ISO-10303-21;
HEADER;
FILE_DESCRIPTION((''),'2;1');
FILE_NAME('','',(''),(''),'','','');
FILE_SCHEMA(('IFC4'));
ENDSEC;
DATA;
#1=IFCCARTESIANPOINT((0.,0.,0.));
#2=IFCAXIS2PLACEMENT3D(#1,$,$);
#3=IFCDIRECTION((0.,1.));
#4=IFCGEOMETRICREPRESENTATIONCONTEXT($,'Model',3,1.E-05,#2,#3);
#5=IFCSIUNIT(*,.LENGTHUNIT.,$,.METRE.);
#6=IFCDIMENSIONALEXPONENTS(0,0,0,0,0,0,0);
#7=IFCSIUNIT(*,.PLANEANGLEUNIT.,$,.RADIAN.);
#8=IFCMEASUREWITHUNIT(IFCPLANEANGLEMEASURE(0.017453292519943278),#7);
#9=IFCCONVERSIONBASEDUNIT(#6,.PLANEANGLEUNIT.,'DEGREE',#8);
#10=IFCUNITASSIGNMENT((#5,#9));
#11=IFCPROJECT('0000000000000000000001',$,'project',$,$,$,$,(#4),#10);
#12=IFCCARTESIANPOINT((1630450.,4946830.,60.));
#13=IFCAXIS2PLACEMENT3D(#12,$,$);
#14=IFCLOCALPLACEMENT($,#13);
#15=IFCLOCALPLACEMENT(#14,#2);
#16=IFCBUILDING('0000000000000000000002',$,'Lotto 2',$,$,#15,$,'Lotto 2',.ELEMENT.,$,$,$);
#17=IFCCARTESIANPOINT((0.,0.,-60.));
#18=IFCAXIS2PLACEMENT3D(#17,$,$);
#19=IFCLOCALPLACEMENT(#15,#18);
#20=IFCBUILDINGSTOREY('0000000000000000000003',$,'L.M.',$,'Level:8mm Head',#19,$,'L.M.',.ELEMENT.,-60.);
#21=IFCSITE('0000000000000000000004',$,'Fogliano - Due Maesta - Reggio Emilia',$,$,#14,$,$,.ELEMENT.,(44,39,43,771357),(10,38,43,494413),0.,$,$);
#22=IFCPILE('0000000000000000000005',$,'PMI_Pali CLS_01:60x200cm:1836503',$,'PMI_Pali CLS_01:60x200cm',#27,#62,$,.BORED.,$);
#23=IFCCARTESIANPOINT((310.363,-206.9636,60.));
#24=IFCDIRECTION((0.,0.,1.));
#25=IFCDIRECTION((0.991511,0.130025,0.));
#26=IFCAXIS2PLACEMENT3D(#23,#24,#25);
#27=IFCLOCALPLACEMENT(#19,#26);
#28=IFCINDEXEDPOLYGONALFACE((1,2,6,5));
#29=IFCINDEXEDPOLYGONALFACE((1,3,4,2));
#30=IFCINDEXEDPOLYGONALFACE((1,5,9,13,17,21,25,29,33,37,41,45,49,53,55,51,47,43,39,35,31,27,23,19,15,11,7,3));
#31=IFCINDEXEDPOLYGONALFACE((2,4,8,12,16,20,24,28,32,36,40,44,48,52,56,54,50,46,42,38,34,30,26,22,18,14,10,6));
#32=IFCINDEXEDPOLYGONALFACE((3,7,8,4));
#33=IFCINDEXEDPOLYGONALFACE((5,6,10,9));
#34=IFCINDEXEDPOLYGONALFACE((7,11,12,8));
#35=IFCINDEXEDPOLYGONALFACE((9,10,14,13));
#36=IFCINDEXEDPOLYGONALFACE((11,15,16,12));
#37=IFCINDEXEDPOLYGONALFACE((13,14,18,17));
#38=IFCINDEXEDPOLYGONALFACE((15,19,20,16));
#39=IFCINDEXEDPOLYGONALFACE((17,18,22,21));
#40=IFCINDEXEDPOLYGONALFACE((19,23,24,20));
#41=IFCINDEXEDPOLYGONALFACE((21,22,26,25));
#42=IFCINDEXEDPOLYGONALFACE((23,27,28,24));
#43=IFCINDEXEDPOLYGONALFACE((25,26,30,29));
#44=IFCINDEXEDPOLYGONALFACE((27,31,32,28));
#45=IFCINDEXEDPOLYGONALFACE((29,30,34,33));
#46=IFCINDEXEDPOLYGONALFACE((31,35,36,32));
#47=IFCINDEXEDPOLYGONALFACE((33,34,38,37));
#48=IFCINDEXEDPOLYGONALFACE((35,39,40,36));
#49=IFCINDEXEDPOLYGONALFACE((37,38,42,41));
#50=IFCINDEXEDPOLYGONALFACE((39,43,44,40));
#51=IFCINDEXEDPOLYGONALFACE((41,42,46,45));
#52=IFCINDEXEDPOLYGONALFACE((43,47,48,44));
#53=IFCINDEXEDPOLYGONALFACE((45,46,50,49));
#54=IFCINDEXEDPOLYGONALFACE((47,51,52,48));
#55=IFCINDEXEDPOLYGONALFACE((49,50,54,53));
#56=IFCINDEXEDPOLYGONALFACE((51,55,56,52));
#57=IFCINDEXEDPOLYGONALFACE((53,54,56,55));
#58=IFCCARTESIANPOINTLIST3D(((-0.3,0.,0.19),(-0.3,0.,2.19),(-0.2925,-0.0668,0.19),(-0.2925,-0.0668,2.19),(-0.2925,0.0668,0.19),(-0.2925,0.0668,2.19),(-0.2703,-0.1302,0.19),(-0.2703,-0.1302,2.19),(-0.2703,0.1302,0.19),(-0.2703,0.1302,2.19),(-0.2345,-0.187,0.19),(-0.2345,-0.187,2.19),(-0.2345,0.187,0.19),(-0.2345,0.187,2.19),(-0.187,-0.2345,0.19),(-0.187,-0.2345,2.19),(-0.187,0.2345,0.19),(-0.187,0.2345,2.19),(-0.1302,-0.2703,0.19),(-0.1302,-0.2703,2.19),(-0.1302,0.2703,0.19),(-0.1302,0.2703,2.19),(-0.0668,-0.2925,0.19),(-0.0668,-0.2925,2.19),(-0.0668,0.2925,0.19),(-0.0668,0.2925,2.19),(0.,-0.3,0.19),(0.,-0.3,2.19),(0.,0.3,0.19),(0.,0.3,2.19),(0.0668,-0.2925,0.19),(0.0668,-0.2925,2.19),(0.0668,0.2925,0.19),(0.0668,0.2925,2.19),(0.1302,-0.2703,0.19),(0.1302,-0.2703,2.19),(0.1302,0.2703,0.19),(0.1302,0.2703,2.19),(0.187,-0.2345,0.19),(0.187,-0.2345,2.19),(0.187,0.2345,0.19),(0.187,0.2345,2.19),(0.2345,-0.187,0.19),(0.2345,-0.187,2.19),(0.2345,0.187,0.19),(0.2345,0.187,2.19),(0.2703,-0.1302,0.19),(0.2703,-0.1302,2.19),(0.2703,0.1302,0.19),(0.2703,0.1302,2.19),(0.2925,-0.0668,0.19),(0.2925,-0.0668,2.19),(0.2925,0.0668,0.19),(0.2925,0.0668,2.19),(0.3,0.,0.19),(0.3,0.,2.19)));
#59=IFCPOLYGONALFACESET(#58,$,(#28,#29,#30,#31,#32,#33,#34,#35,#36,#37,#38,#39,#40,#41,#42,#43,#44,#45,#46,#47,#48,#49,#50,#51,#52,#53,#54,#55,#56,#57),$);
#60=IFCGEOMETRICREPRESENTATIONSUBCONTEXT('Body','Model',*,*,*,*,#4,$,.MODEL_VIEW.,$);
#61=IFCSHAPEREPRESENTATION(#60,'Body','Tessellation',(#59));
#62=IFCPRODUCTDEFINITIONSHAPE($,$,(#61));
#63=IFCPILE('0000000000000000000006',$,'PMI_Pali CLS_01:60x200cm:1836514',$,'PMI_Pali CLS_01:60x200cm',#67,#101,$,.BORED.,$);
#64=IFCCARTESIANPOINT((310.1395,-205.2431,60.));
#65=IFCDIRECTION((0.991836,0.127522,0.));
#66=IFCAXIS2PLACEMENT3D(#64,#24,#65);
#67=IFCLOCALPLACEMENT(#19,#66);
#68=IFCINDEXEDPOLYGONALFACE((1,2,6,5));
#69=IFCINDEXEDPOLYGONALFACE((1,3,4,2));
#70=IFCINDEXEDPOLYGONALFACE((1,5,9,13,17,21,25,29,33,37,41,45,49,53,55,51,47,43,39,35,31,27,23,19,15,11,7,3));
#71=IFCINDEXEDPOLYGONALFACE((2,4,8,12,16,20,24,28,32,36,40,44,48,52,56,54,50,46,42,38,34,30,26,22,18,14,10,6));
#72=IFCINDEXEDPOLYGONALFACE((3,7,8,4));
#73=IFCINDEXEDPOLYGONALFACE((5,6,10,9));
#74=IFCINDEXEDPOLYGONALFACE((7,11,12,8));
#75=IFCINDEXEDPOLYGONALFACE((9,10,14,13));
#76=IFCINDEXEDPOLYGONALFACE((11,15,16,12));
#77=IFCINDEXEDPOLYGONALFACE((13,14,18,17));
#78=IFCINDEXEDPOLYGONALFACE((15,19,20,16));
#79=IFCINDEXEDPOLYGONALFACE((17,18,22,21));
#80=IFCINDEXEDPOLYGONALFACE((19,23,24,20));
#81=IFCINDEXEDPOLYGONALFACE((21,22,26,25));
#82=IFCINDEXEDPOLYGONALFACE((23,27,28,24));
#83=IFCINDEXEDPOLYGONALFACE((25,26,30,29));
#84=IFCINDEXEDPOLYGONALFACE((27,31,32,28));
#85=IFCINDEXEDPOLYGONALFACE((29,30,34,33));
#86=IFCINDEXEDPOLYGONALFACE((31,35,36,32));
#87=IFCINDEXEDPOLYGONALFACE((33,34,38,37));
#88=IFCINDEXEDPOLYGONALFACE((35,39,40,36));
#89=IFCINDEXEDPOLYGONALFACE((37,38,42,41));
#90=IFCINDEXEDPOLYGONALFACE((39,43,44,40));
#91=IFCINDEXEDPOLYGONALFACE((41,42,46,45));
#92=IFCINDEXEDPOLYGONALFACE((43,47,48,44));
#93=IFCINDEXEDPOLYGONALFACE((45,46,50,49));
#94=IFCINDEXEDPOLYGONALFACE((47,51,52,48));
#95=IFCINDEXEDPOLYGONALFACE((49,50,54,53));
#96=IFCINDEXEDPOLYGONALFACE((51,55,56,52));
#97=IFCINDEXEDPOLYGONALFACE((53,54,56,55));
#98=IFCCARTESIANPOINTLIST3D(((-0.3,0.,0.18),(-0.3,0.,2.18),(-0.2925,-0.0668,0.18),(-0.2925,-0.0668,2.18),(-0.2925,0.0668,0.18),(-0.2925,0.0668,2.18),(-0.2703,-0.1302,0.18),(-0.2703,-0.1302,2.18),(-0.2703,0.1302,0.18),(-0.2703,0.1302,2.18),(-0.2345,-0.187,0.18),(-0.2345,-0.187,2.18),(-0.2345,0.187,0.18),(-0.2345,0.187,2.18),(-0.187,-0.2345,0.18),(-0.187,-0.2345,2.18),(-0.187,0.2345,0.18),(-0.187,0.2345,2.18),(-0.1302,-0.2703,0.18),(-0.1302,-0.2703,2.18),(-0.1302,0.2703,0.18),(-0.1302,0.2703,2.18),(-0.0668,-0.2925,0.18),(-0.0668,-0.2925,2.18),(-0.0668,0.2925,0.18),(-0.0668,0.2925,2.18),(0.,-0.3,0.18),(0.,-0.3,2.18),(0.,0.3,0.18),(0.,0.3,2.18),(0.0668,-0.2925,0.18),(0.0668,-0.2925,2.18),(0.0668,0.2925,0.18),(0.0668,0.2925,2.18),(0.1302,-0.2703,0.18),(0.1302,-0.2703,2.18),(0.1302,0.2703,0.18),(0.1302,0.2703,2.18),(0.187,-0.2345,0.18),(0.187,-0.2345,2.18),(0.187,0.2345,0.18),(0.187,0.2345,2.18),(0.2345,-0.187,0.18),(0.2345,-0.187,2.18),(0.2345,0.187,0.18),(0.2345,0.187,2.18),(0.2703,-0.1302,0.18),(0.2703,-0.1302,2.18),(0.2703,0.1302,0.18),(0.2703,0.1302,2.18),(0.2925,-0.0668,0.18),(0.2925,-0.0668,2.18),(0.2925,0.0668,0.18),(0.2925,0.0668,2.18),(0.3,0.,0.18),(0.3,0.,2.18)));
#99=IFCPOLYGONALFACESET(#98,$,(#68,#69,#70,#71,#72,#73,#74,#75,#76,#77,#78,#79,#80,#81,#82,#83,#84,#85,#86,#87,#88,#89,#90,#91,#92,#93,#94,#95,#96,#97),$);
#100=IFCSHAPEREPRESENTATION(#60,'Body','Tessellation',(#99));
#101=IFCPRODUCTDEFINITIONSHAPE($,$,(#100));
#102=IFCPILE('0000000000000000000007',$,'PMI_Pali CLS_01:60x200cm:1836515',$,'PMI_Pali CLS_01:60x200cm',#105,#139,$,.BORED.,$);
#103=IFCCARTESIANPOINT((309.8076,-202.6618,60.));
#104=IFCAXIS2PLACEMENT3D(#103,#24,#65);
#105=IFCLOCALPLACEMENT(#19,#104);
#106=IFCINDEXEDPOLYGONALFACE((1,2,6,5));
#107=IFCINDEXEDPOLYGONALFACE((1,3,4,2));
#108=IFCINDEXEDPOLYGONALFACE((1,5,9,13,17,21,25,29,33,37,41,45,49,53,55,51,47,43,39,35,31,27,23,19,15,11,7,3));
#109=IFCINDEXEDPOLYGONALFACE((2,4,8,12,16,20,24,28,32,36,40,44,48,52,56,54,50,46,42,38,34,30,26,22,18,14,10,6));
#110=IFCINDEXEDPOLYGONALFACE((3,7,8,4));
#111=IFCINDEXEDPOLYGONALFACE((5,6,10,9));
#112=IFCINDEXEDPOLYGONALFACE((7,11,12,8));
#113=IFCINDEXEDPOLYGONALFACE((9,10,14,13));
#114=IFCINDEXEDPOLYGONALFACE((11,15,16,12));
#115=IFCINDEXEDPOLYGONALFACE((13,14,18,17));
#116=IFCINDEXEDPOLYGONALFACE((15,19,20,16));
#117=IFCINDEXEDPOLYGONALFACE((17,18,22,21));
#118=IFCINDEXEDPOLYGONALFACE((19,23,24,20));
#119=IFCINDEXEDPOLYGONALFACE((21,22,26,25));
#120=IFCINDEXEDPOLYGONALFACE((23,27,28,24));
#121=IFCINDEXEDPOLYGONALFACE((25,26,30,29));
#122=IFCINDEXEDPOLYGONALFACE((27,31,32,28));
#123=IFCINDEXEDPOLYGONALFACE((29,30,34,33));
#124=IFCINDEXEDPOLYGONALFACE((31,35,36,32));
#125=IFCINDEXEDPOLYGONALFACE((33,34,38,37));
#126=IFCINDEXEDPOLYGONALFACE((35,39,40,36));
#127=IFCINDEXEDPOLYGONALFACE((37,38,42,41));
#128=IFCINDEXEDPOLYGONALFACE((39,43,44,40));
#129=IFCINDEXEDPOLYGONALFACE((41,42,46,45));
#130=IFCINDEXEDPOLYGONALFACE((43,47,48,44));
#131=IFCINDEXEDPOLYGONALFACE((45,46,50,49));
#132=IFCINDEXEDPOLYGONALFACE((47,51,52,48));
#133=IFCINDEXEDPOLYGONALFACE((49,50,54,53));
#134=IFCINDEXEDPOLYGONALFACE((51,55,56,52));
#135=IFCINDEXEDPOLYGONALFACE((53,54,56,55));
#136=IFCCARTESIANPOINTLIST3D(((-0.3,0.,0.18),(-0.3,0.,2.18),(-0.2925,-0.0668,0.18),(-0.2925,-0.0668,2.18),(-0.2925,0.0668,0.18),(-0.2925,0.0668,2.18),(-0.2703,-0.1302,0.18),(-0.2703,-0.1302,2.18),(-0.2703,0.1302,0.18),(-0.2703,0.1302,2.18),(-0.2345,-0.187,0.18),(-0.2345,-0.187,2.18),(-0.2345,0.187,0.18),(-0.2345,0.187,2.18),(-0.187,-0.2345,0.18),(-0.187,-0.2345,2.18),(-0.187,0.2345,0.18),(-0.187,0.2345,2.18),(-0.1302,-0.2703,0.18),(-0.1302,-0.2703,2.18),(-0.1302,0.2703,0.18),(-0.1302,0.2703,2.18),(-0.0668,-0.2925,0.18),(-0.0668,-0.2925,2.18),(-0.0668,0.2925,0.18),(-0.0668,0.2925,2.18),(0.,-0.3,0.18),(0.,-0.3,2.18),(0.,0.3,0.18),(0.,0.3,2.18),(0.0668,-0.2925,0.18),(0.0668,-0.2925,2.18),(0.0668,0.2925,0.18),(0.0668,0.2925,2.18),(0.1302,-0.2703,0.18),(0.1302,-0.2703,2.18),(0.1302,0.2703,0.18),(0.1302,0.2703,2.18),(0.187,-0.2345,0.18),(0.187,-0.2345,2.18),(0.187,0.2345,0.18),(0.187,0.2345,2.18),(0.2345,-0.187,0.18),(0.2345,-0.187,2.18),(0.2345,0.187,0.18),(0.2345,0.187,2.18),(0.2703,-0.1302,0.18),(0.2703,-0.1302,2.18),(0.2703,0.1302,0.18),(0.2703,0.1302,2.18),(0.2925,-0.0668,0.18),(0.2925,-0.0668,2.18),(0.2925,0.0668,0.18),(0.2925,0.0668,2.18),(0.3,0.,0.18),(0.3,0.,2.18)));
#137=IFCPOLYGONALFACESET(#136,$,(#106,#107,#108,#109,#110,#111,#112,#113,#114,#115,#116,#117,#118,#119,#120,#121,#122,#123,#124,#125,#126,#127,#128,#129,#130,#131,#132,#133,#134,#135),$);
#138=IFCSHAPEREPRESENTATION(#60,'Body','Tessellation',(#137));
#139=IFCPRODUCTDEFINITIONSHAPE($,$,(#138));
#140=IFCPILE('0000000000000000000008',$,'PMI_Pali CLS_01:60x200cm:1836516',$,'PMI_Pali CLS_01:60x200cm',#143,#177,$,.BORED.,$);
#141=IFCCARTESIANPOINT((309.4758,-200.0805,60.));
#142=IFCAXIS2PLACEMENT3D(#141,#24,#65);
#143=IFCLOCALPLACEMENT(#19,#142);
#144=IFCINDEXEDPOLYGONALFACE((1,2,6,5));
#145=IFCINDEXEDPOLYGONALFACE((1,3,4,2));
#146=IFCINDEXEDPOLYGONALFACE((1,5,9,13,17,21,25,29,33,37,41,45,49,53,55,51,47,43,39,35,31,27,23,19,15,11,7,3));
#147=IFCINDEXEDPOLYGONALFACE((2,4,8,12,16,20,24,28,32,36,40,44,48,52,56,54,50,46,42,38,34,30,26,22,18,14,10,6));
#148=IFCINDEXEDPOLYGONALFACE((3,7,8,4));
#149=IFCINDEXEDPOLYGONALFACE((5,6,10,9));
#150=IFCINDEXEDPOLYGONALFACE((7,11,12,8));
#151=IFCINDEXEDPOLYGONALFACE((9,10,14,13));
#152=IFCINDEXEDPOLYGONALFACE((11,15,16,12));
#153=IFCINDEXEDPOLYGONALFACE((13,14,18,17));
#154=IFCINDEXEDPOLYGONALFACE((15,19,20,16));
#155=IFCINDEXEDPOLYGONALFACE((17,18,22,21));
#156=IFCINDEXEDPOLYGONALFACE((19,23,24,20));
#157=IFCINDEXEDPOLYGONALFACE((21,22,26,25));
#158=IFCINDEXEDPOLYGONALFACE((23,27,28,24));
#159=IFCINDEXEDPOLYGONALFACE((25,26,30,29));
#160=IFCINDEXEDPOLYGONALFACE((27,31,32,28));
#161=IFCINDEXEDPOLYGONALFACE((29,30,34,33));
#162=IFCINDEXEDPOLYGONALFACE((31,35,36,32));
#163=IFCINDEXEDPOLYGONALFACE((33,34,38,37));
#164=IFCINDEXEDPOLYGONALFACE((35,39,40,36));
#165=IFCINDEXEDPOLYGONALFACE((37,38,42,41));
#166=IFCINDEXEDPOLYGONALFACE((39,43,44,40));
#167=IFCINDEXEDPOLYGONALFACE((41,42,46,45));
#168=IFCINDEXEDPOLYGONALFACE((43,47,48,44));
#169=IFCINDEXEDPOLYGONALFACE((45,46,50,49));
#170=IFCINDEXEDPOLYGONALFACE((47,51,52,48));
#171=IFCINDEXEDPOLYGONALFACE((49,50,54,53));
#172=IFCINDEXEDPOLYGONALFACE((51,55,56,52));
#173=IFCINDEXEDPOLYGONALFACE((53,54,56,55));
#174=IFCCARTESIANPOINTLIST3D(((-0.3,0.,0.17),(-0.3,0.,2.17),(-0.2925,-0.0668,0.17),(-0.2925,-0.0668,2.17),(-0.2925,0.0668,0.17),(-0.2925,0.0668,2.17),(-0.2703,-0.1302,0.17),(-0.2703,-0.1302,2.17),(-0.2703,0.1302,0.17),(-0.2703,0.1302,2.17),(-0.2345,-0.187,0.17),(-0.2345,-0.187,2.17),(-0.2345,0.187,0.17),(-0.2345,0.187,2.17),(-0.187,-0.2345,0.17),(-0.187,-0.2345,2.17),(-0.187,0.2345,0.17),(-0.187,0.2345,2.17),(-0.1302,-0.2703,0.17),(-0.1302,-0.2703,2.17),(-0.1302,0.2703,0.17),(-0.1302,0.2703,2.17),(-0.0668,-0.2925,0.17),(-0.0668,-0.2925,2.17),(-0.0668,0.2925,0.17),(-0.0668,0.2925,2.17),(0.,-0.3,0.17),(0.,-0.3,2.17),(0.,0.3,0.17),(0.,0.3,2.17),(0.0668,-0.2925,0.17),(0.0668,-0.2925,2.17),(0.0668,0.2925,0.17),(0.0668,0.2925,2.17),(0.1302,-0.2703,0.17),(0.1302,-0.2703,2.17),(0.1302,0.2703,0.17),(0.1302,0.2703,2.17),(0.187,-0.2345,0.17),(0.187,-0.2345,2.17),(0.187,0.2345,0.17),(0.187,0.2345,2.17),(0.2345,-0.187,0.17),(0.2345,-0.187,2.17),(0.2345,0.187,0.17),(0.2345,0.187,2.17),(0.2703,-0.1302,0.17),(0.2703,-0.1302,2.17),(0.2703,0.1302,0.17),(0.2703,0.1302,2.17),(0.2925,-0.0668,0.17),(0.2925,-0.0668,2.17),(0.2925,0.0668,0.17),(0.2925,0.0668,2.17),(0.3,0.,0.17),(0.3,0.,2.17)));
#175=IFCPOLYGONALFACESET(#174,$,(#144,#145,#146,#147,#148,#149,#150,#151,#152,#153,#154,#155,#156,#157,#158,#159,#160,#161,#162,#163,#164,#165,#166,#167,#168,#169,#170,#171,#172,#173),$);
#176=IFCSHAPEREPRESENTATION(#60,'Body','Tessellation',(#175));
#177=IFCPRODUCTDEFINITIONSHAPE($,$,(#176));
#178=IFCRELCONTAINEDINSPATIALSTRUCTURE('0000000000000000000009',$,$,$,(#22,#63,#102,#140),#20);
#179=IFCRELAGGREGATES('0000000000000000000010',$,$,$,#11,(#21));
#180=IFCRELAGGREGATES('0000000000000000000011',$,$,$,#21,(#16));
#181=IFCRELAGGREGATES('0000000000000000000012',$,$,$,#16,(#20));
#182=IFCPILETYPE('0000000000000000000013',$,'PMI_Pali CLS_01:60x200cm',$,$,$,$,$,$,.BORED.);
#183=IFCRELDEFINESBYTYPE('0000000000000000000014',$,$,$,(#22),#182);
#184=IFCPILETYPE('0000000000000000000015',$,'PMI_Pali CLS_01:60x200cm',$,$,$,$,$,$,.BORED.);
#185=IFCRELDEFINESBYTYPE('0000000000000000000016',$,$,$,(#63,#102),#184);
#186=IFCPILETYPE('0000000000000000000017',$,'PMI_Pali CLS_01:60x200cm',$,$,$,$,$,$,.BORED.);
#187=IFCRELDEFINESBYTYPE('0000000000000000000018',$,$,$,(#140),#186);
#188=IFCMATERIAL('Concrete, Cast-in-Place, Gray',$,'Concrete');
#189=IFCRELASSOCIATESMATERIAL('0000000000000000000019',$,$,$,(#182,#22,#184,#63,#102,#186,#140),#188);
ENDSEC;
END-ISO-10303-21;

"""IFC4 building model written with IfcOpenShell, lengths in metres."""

from ifc_helpers import new_model, entity, si_unit, converted_unit, direction, frame, origin, place, context, subcontext, project, spatial, arc, indexed_curve, outline, extrude, source, transform, mapped, material, type_object, type_shapes, element, save


model = new_model("IFC4")

# Units and contexts
model_context = context("Model", 3, precision=1e-05, world=origin(), true_north=direction((0.0, 1.0)))
body_context = subcontext(model_context, "Body", "Model", "MODEL_VIEW")
ifc_project = project(units=[si_unit("LENGTHUNIT", "METRE"), converted_unit("PLANEANGLEUNIT", "DEGREE", entity("IfcPlaneAngleMeasure", 0.017453292519943278), si_unit("PLANEANGLEUNIT", "RADIAN"), dimensions=[0, 0, 0, 0, 0, 0, 0])], contexts=[model_context])

# Site, building, storey
site_placement = place(None, frame((1630450.0, 4946830.0, 60.0)))
site = spatial("IfcSite", under=ifc_project, at=site_placement, Name="Fogliano - Due Maesta - Reggio Emilia", CompositionType="ELEMENT", RefLatitude=(44, 39, 43, 771357), RefLongitude=(10, 38, 43, 494413), RefElevation=0.0)
building_placement = place(site_placement, origin())
building = spatial("IfcBuilding", under=site, at=building_placement, Name="Lotto 2", LongName="Lotto 2", CompositionType="ELEMENT")
storey_placement = place(building_placement, frame((0.0, 0.0, -60.0)))
storey = spatial("IfcBuildingStorey", under=building, at=storey_placement, Name="L.M.", ObjectType="Level:8mm Head", LongName="L.M.", CompositionType="ELEMENT", Elevation=-60.0)

# Piles
ifc_material_1 = material(Name="Concrete, Cast-in-Place, Gray", Category="Concrete")
pile_type_1 = type_object("IfcPileType", Name="PMI_Pali CLS_01:60x200cm", PredefinedType="BORED", material=ifc_material_1)
shared_shape_1 = source(origin(), body_context, "Body", "SweptSolid", [
    extrude(outline(indexed_curve([(-0.3, 0.0), (0.0, -0.3), (0.3, 0.0), (0.0, 0.3)], segments=[arc(1, 2, 3), arc(3, 4, 1)], self_intersect=False)), frame((0.0, 0.0, 0.19)), (0.0, 0.0, 1.0), 2.0),
])
type_shapes(pile_type_1, [shared_shape_1])
pile_1_placement = place(storey_placement, frame((310.363, -206.9636, 60.0), z_axis=(0.0, 0.0, 1.0), x_axis=(0.991511, 0.130025, 0.0)))
element("IfcPile", 1, at=pile_1_placement, inside=storey, type_object=pile_type_1, material=ifc_material_1, Name="PMI_Pali CLS_01:60x200cm:1836503", ObjectType="PMI_Pali CLS_01:60x200cm", PredefinedType="BORED", context=body_context, shape_type="MappedRepresentation", body=[
    mapped(shared_shape_1, transform((0.0, 0.0, 0.0), scale=1.0)),
])
pile_type_2 = type_object("IfcPileType", Name="PMI_Pali CLS_01:60x200cm", PredefinedType="BORED", material=ifc_material_1)
shared_shape_2 = source(origin(), body_context, "Body", "SweptSolid", [
    extrude(outline(indexed_curve([(-0.3, 0.0), (0.0, -0.3), (0.3, 0.0), (0.0, 0.3)], segments=[arc(1, 2, 3), arc(3, 4, 1)], self_intersect=False)), frame((0.0, 0.0, 0.18)), (0.0, 0.0, 1.0), 2.0),
])
type_shapes(pile_type_2, [shared_shape_2])
for number, where, z_axis, x_axis, name in (
    (2, (310.1395, -205.2431, 60.0), (0.0, 0.0, 1.0), (0.991836, 0.127522, 0.0), "PMI_Pali CLS_01:60x200cm:1836514"),
    (3, (309.8076, -202.6618, 60.0), (0.0, 0.0, 1.0), (0.991836, 0.127522, 0.0), "PMI_Pali CLS_01:60x200cm:1836515"),
):
    element("IfcPile", number, at=place(storey_placement, frame(where, z_axis=z_axis, x_axis=x_axis)), inside=storey, type_object=pile_type_2, material=ifc_material_1, Name=name, ObjectType="PMI_Pali CLS_01:60x200cm", PredefinedType="BORED", context=body_context, shape_type="MappedRepresentation", body=[
        mapped(shared_shape_2, transform((0.0, 0.0, 0.0), scale=1.0)),
    ])
pile_type_3 = type_object("IfcPileType", Name="PMI_Pali CLS_01:60x200cm", PredefinedType="BORED", material=ifc_material_1)
shared_shape_3 = source(origin(), body_context, "Body", "SweptSolid", [
    extrude(outline(indexed_curve([(-0.3, 0.0), (0.0, -0.3), (0.3, 0.0), (0.0, 0.3)], segments=[arc(1, 2, 3), arc(3, 4, 1)], self_intersect=False)), frame((0.0, 0.0, 0.17)), (0.0, 0.0, 1.0), 2.0),
])
type_shapes(pile_type_3, [shared_shape_3])
pile_2_placement = place(storey_placement, frame((309.4758, -200.0805, 60.0), z_axis=(0.0, 0.0, 1.0), x_axis=(0.991836, 0.127522, 0.0)))
element("IfcPile", 4, at=pile_2_placement, inside=storey, type_object=pile_type_3, material=ifc_material_1, Name="PMI_Pali CLS_01:60x200cm:1836516", ObjectType="PMI_Pali CLS_01:60x200cm", PredefinedType="BORED", context=body_context, shape_type="MappedRepresentation", body=[
    mapped(shared_shape_3, transform((0.0, 0.0, 0.0), scale=1.0)),
])

save(model, "model.ifc")
